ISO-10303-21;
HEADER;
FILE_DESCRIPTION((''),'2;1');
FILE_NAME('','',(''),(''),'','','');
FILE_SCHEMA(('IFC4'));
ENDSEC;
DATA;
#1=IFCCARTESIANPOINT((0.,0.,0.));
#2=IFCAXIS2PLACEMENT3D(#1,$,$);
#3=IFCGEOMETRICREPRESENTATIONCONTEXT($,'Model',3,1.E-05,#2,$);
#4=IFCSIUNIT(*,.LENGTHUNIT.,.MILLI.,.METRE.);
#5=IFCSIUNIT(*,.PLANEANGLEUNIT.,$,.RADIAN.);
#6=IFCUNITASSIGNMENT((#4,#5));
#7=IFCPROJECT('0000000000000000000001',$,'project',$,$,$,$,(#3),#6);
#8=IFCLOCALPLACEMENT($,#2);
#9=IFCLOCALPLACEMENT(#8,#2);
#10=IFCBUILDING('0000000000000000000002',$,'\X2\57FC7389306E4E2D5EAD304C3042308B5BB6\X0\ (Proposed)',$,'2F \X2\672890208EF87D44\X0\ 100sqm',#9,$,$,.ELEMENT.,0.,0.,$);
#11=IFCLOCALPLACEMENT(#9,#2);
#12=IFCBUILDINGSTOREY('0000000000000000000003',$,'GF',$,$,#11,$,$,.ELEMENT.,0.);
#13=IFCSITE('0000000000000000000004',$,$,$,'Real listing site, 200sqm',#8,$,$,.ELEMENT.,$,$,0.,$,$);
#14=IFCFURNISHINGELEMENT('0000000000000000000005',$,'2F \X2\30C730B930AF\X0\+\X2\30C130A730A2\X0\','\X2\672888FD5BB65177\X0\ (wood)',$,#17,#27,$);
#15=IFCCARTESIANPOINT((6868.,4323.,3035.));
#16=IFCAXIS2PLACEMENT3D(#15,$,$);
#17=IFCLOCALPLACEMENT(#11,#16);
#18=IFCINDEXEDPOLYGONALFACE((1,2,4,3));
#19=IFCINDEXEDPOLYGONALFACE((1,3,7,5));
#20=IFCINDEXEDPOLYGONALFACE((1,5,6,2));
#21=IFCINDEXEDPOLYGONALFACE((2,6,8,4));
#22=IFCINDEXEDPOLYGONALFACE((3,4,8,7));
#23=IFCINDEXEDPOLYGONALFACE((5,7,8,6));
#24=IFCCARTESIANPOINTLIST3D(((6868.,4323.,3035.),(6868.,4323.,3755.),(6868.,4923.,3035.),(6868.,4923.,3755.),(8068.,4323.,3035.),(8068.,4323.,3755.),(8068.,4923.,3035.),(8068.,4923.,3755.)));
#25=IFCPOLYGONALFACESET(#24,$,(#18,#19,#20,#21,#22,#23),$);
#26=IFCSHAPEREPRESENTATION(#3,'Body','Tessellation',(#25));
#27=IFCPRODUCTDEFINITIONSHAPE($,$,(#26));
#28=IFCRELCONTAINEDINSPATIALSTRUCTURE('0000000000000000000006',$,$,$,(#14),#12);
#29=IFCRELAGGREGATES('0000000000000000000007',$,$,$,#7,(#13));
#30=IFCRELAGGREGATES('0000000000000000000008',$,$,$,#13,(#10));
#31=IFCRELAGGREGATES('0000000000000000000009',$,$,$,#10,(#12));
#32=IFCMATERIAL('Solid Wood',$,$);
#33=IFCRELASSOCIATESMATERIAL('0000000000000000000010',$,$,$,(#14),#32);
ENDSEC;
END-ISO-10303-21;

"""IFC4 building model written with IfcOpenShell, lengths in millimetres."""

from ifc_helpers import new_model, si_unit, frame, frame_2d, origin, place, context, project, spatial, rectangle, extrude, material, element, save


model = new_model("IFC4")

# Units and contexts
model_context = context("Model", 3, precision=1e-05, world=origin())
ifc_project = project(units=[si_unit("LENGTHUNIT", "METRE", prefix="MILLI"), si_unit("PLANEANGLEUNIT", "RADIAN")], contexts=[model_context])

# Site, building, storey
site_placement = place(None, origin())
site = spatial("IfcSite", under=ifc_project, at=site_placement, ObjectType="Real listing site, 200sqm", CompositionType="ELEMENT", RefElevation=0.0)
building_placement = place(site_placement, origin())
building = spatial("IfcBuilding", under=site, at=building_placement, Name="埼玉の中庭がある家 (Proposed)", ObjectType="2F 木造軸組 100sqm", CompositionType="ELEMENT", ElevationOfRefHeight=0.0, ElevationOfTerrain=0.0)
storey_placement = place(building_placement, origin())
storey = spatial("IfcBuildingStorey", under=building, at=storey_placement, Name="GF", CompositionType="ELEMENT", Elevation=0.0)

# Shared definitions
ifc_material_1 = material(Name="Solid Wood")

# Furnishing element
furnishing_1_placement = place(storey_placement, frame((6868.0, 4323.0, 3035.0)))
element("IfcFurnishingElement", 1, at=furnishing_1_placement, inside=storey, material=ifc_material_1, Name="2F デスク+チェア", Description="木製家具 (wood)", context=model_context, shape_type="SweptSolid", body=[
    extrude(rectangle(XDim=1200.0, YDim=600.0, at=frame_2d((600.0, 300.0))), frame((6868.0, 4323.0, 3035.0)), (0.0, 0.0, 1.0), 720.0),
])

save(model, "model.ifc")
